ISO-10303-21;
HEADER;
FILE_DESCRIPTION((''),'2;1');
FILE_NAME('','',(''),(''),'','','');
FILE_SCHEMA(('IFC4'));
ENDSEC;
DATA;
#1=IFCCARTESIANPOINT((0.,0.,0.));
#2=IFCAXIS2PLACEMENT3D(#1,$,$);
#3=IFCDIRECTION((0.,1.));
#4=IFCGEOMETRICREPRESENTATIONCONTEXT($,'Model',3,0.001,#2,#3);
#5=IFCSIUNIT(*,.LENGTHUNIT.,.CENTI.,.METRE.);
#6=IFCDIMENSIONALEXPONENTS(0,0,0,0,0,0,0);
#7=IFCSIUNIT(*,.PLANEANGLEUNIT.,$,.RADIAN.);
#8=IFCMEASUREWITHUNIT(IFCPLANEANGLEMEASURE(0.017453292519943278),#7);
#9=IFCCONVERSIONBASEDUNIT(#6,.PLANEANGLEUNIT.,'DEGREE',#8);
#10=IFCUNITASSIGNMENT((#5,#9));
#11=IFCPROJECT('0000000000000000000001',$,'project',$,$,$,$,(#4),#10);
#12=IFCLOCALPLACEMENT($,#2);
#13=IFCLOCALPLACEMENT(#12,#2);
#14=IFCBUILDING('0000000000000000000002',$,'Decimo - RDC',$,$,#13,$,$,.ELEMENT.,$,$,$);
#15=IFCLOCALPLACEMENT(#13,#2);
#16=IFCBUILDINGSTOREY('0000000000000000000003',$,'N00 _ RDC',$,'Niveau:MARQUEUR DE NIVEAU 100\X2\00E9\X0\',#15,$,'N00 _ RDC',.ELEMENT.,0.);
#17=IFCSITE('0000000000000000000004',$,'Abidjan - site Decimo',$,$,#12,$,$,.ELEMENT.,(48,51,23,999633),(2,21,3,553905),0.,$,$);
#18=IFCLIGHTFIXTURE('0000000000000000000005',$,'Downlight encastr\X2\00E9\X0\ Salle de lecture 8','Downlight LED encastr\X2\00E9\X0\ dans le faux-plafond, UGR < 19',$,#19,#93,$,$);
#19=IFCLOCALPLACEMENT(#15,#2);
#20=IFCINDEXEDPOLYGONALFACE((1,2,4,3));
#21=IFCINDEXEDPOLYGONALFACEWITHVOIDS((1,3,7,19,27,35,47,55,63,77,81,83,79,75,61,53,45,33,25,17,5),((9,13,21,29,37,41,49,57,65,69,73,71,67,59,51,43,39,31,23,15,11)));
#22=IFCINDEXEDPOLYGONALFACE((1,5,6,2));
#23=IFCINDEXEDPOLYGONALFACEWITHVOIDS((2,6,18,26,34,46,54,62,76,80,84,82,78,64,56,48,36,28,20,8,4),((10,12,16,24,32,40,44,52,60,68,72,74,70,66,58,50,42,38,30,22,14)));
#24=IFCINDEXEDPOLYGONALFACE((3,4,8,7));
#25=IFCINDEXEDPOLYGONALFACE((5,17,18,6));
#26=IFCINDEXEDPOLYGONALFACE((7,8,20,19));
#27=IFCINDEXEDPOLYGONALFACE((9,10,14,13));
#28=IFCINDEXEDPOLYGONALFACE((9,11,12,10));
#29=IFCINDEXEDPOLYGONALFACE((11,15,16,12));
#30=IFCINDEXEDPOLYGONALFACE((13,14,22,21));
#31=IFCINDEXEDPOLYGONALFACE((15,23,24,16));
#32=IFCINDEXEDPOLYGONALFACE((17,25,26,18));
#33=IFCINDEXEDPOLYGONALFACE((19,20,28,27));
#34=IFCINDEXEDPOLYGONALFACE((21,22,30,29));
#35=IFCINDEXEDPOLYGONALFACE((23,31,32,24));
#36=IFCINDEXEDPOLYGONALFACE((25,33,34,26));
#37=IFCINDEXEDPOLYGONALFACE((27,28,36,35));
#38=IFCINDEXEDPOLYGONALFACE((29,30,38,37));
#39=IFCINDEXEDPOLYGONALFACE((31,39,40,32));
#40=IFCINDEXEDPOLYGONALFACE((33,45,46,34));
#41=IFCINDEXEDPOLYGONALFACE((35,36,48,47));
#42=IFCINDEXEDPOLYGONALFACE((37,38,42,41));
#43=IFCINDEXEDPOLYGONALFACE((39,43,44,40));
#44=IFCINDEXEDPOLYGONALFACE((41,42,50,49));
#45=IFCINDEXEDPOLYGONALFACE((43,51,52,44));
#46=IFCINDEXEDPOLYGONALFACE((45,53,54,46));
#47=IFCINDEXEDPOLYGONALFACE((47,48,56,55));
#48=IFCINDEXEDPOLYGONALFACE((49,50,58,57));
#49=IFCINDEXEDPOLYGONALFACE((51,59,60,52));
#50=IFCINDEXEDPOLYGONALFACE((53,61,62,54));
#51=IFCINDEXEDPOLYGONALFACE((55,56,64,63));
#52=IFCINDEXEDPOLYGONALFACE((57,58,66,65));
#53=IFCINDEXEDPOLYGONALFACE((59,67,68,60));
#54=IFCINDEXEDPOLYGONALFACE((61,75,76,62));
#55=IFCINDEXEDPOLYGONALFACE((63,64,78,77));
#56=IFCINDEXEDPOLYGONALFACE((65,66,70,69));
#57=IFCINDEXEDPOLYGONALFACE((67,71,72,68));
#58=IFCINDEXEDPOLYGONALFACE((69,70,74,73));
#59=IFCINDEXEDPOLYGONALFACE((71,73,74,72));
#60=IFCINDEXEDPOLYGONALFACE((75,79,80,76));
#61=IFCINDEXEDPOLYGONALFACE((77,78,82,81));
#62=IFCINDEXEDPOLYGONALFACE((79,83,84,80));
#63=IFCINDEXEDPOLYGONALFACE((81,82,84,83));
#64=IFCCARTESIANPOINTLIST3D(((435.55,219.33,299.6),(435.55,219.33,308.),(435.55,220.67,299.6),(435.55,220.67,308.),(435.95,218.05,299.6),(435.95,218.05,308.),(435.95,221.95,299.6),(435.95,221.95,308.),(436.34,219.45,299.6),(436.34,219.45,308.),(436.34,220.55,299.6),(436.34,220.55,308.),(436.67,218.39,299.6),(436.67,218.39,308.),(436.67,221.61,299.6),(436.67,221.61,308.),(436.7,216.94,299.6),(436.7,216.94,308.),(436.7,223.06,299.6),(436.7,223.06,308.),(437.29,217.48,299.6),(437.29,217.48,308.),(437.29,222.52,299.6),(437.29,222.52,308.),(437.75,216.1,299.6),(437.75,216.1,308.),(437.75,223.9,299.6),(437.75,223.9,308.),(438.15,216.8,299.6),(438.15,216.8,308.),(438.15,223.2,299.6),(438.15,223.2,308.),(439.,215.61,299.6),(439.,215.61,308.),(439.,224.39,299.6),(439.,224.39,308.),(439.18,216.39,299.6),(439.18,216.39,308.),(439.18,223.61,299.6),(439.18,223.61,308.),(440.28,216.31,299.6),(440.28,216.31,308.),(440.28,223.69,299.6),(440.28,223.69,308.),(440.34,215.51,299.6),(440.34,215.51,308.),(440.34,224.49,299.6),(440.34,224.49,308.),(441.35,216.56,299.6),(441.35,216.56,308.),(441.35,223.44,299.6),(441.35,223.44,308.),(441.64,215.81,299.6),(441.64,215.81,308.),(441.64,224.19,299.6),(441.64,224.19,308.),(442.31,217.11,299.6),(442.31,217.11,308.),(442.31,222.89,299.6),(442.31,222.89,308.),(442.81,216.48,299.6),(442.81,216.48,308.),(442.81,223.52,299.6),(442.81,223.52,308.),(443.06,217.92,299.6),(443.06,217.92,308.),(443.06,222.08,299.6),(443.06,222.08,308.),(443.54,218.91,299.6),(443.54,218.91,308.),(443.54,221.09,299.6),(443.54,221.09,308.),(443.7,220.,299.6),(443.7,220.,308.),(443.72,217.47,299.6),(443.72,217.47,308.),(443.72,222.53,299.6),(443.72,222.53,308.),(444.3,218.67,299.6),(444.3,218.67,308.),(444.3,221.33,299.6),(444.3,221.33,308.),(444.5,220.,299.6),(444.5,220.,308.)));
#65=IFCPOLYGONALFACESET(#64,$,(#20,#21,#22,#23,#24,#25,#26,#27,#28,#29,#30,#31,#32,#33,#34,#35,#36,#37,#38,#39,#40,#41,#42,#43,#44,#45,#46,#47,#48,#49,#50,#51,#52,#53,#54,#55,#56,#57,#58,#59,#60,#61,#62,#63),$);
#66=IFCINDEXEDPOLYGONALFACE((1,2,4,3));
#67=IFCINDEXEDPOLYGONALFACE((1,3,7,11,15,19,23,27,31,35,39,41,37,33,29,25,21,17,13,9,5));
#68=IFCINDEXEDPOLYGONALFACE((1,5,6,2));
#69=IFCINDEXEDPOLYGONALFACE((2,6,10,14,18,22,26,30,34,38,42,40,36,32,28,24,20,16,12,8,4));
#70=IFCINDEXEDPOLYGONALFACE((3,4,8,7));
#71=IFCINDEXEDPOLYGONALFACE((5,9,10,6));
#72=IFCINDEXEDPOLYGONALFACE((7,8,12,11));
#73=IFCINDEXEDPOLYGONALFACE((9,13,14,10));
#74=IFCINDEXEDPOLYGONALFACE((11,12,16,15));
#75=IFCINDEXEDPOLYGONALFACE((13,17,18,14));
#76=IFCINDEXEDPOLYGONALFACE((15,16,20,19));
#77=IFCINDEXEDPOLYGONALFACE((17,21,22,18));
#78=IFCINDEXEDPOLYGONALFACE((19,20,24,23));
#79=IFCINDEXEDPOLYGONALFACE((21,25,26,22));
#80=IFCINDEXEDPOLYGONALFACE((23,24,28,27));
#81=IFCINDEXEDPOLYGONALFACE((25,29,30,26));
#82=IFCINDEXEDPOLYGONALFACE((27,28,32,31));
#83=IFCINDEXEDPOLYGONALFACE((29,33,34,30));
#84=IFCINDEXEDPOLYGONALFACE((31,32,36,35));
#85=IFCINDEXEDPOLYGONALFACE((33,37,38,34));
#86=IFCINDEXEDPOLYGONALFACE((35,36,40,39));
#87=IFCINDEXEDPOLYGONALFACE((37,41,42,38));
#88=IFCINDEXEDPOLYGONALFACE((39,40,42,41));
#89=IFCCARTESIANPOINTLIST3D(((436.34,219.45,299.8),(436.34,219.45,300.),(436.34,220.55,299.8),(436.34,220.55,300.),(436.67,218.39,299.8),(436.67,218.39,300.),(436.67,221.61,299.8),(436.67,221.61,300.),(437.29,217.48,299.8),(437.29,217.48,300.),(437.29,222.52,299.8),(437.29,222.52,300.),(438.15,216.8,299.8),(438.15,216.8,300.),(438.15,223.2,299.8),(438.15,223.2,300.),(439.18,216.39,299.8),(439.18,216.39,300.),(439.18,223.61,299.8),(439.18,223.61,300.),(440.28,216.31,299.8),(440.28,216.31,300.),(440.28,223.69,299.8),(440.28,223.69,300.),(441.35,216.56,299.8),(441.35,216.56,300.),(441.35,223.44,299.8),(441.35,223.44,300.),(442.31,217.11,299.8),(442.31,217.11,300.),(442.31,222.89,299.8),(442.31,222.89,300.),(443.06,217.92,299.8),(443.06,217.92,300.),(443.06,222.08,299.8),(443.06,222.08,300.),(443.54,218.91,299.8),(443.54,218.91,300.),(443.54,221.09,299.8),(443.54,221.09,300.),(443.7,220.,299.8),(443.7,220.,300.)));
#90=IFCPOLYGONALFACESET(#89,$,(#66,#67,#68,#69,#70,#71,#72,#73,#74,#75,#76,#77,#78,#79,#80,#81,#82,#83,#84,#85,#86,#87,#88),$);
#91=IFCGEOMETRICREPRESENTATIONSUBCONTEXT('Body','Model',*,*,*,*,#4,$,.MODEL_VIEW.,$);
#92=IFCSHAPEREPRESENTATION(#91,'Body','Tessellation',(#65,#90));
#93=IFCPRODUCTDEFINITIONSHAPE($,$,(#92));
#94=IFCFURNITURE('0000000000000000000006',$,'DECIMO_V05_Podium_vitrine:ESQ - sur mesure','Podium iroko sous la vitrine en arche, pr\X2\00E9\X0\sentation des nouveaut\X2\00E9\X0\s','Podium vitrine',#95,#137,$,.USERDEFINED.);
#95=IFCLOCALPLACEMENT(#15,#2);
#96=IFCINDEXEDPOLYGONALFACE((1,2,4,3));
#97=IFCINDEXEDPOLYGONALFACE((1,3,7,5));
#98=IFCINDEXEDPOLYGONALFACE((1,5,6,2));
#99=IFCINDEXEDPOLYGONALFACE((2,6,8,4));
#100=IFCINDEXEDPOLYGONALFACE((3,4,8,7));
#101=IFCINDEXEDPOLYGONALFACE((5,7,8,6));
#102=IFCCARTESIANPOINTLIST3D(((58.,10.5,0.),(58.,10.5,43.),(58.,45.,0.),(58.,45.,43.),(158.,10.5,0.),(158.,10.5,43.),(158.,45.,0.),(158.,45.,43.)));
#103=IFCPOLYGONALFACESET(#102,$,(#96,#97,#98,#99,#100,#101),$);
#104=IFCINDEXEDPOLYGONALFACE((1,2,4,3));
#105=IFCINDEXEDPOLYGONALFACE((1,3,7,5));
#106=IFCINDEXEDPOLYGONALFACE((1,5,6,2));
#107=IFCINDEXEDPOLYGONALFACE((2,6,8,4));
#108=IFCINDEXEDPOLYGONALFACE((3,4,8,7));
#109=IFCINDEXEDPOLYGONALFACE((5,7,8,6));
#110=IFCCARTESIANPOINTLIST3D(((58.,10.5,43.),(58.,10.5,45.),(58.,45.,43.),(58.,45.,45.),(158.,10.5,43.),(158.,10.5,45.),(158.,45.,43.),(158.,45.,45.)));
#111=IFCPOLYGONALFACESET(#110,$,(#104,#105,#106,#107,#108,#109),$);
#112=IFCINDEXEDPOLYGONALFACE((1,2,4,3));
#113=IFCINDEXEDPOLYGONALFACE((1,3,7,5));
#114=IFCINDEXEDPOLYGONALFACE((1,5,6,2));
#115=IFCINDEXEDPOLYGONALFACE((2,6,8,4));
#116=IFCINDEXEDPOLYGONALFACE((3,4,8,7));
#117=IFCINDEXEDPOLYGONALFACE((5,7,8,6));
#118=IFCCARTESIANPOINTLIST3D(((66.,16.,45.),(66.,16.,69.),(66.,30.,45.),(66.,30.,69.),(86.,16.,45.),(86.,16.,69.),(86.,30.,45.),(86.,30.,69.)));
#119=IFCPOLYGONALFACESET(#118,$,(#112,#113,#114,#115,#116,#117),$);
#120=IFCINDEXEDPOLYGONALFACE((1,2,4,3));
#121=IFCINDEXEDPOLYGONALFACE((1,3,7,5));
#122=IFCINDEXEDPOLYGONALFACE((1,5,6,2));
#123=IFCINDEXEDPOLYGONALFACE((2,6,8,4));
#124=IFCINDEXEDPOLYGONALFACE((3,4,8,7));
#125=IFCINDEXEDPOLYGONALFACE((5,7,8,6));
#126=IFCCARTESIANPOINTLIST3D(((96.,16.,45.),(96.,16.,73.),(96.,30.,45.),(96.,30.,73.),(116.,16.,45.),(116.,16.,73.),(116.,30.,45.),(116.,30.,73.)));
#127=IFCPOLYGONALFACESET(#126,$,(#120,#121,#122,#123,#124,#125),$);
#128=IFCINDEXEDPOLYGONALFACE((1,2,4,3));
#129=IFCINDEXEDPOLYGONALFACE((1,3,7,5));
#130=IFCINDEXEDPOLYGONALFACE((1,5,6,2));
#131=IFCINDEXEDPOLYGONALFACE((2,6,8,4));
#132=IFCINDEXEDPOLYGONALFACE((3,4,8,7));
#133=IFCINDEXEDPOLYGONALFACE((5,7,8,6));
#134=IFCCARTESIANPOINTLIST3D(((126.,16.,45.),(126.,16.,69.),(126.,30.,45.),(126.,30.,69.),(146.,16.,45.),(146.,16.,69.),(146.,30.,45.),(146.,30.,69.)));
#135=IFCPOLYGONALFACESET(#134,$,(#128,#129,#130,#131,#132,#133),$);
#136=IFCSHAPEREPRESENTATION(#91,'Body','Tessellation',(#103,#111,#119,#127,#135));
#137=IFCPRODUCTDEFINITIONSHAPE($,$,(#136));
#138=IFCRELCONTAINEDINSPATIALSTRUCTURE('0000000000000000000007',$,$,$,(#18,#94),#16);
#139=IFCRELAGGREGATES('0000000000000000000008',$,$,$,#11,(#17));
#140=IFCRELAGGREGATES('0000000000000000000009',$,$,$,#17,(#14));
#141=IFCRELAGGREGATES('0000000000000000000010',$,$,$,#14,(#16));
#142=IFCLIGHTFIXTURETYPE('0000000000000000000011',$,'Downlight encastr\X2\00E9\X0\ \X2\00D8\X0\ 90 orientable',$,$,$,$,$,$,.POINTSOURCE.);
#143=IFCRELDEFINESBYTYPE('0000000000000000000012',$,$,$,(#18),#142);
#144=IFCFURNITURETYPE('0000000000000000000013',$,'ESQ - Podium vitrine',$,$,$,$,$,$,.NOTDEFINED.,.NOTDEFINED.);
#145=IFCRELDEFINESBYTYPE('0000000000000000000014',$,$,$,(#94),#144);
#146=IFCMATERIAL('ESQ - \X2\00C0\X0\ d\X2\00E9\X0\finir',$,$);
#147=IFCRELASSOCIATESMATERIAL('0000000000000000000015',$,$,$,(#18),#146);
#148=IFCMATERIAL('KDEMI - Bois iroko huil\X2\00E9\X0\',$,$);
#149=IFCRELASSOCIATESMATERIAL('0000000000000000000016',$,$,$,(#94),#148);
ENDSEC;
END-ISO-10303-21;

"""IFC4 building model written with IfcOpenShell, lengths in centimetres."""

from ifc_helpers import new_model, entity, si_unit, converted_unit, direction, frame, frame_2d, origin, origin_with_axes, place, context, subcontext, project, spatial, rectangle, circle, hollow_circle, extrude, material, type_object, element, save


model = new_model("IFC4")

# Units and contexts
model_context = context("Model", 3, precision=0.001, world=origin(), true_north=direction((0.0, 1.0)))
body_context = subcontext(model_context, "Body", "Model", "MODEL_VIEW")
ifc_project = project(units=[si_unit("LENGTHUNIT", "METRE", prefix="CENTI"), converted_unit("PLANEANGLEUNIT", "DEGREE", entity("IfcPlaneAngleMeasure", 0.017453292519943278), si_unit("PLANEANGLEUNIT", "RADIAN"), dimensions=[0, 0, 0, 0, 0, 0, 0])], contexts=[model_context])

# Site, building, storey
site_placement = place(None, origin())
site = spatial("IfcSite", under=ifc_project, at=site_placement, Name="Abidjan - site Decimo", CompositionType="ELEMENT", RefLatitude=(48, 51, 23, 999633), RefLongitude=(2, 21, 3, 553905), RefElevation=0.0)
building_placement = place(site_placement, origin())
building = spatial("IfcBuilding", under=site, at=building_placement, Name="Decimo - RDC", CompositionType="ELEMENT")
storey_placement = place(building_placement, origin())
storey = spatial("IfcBuildingStorey", under=building, at=storey_placement, Name="N00 _ RDC", ObjectType="Niveau:MARQUEUR DE NIVEAU 100é", LongName="N00 _ RDC", CompositionType="ELEMENT", Elevation=0.0)

# Shared definitions
ifc_material_1 = material(Name="KDEMI - Bois iroko huilé")

# Light fixture
ifc_material_2 = material(Name="ESQ - À définir")
light_fixture_type_1 = type_object("IfcLightFixtureType", Name="Downlight encastré Ø 90 orientable", PredefinedType="POINTSOURCE")
light_fixture_1_placement = place(storey_placement, origin_with_axes())
element("IfcLightFixture", 1, at=light_fixture_1_placement, inside=storey, type_object=light_fixture_type_1, material=ifc_material_2, Name="Downlight encastré Salle de lecture 8", Description="Downlight LED encastré dans le faux-plafond, UGR < 19", context=body_context, shape_type="SweptSolid", body=[
    extrude(hollow_circle(Radius=4.5, WallThickness=0.8, at=frame_2d((440.0, 220.0))), frame((0.0, 0.0, 299.6)), (0.0, 0.0, 1.0), 8.4),
    extrude(circle(Radius=3.7, at=frame_2d((440.0, 220.0))), frame((0.0, 0.0, 299.8)), (0.0, 0.0, 1.0), 0.2),
])

# Furniture
furniture_type_1 = type_object("IfcFurnitureType", Name="ESQ - Podium vitrine", AssemblyPlace="NOTDEFINED", PredefinedType="NOTDEFINED")
furniture_1_placement = place(storey_placement, origin_with_axes())
element("IfcFurniture", 2, at=furniture_1_placement, inside=storey, type_object=furniture_type_1, material=ifc_material_1, Name="DECIMO_V05_Podium_vitrine:ESQ - sur mesure", Description="Podium iroko sous la vitrine en arche, présentation des nouveautés", ObjectType="Podium vitrine", PredefinedType="USERDEFINED", context=body_context, shape_type="SweptSolid", body=[
    extrude(rectangle(XDim=100.0, YDim=34.5, at=frame_2d((108.0, 27.75))), origin(), (0.0, 0.0, 1.0), 43.0),
    extrude(rectangle(XDim=100.0, YDim=34.5, at=frame_2d((108.0, 27.75))), frame((0.0, 0.0, 43.0)), (0.0, 0.0, 1.0), 2.0),
    extrude(rectangle(XDim=20.0, YDim=14.0, at=frame_2d((76.0, 23.0))), frame((0.0, 0.0, 45.0)), (0.0, 0.0, 1.0), 24.0),
    extrude(rectangle(XDim=20.0, YDim=14.0, at=frame_2d((106.0, 23.0))), frame((0.0, 0.0, 45.0)), (0.0, 0.0, 1.0), 28.0),
    extrude(rectangle(XDim=20.0, YDim=14.0, at=frame_2d((136.0, 23.0))), frame((0.0, 0.0, 45.0)), (0.0, 0.0, 1.0), 24.0),
])

save(model, "model.ifc")
